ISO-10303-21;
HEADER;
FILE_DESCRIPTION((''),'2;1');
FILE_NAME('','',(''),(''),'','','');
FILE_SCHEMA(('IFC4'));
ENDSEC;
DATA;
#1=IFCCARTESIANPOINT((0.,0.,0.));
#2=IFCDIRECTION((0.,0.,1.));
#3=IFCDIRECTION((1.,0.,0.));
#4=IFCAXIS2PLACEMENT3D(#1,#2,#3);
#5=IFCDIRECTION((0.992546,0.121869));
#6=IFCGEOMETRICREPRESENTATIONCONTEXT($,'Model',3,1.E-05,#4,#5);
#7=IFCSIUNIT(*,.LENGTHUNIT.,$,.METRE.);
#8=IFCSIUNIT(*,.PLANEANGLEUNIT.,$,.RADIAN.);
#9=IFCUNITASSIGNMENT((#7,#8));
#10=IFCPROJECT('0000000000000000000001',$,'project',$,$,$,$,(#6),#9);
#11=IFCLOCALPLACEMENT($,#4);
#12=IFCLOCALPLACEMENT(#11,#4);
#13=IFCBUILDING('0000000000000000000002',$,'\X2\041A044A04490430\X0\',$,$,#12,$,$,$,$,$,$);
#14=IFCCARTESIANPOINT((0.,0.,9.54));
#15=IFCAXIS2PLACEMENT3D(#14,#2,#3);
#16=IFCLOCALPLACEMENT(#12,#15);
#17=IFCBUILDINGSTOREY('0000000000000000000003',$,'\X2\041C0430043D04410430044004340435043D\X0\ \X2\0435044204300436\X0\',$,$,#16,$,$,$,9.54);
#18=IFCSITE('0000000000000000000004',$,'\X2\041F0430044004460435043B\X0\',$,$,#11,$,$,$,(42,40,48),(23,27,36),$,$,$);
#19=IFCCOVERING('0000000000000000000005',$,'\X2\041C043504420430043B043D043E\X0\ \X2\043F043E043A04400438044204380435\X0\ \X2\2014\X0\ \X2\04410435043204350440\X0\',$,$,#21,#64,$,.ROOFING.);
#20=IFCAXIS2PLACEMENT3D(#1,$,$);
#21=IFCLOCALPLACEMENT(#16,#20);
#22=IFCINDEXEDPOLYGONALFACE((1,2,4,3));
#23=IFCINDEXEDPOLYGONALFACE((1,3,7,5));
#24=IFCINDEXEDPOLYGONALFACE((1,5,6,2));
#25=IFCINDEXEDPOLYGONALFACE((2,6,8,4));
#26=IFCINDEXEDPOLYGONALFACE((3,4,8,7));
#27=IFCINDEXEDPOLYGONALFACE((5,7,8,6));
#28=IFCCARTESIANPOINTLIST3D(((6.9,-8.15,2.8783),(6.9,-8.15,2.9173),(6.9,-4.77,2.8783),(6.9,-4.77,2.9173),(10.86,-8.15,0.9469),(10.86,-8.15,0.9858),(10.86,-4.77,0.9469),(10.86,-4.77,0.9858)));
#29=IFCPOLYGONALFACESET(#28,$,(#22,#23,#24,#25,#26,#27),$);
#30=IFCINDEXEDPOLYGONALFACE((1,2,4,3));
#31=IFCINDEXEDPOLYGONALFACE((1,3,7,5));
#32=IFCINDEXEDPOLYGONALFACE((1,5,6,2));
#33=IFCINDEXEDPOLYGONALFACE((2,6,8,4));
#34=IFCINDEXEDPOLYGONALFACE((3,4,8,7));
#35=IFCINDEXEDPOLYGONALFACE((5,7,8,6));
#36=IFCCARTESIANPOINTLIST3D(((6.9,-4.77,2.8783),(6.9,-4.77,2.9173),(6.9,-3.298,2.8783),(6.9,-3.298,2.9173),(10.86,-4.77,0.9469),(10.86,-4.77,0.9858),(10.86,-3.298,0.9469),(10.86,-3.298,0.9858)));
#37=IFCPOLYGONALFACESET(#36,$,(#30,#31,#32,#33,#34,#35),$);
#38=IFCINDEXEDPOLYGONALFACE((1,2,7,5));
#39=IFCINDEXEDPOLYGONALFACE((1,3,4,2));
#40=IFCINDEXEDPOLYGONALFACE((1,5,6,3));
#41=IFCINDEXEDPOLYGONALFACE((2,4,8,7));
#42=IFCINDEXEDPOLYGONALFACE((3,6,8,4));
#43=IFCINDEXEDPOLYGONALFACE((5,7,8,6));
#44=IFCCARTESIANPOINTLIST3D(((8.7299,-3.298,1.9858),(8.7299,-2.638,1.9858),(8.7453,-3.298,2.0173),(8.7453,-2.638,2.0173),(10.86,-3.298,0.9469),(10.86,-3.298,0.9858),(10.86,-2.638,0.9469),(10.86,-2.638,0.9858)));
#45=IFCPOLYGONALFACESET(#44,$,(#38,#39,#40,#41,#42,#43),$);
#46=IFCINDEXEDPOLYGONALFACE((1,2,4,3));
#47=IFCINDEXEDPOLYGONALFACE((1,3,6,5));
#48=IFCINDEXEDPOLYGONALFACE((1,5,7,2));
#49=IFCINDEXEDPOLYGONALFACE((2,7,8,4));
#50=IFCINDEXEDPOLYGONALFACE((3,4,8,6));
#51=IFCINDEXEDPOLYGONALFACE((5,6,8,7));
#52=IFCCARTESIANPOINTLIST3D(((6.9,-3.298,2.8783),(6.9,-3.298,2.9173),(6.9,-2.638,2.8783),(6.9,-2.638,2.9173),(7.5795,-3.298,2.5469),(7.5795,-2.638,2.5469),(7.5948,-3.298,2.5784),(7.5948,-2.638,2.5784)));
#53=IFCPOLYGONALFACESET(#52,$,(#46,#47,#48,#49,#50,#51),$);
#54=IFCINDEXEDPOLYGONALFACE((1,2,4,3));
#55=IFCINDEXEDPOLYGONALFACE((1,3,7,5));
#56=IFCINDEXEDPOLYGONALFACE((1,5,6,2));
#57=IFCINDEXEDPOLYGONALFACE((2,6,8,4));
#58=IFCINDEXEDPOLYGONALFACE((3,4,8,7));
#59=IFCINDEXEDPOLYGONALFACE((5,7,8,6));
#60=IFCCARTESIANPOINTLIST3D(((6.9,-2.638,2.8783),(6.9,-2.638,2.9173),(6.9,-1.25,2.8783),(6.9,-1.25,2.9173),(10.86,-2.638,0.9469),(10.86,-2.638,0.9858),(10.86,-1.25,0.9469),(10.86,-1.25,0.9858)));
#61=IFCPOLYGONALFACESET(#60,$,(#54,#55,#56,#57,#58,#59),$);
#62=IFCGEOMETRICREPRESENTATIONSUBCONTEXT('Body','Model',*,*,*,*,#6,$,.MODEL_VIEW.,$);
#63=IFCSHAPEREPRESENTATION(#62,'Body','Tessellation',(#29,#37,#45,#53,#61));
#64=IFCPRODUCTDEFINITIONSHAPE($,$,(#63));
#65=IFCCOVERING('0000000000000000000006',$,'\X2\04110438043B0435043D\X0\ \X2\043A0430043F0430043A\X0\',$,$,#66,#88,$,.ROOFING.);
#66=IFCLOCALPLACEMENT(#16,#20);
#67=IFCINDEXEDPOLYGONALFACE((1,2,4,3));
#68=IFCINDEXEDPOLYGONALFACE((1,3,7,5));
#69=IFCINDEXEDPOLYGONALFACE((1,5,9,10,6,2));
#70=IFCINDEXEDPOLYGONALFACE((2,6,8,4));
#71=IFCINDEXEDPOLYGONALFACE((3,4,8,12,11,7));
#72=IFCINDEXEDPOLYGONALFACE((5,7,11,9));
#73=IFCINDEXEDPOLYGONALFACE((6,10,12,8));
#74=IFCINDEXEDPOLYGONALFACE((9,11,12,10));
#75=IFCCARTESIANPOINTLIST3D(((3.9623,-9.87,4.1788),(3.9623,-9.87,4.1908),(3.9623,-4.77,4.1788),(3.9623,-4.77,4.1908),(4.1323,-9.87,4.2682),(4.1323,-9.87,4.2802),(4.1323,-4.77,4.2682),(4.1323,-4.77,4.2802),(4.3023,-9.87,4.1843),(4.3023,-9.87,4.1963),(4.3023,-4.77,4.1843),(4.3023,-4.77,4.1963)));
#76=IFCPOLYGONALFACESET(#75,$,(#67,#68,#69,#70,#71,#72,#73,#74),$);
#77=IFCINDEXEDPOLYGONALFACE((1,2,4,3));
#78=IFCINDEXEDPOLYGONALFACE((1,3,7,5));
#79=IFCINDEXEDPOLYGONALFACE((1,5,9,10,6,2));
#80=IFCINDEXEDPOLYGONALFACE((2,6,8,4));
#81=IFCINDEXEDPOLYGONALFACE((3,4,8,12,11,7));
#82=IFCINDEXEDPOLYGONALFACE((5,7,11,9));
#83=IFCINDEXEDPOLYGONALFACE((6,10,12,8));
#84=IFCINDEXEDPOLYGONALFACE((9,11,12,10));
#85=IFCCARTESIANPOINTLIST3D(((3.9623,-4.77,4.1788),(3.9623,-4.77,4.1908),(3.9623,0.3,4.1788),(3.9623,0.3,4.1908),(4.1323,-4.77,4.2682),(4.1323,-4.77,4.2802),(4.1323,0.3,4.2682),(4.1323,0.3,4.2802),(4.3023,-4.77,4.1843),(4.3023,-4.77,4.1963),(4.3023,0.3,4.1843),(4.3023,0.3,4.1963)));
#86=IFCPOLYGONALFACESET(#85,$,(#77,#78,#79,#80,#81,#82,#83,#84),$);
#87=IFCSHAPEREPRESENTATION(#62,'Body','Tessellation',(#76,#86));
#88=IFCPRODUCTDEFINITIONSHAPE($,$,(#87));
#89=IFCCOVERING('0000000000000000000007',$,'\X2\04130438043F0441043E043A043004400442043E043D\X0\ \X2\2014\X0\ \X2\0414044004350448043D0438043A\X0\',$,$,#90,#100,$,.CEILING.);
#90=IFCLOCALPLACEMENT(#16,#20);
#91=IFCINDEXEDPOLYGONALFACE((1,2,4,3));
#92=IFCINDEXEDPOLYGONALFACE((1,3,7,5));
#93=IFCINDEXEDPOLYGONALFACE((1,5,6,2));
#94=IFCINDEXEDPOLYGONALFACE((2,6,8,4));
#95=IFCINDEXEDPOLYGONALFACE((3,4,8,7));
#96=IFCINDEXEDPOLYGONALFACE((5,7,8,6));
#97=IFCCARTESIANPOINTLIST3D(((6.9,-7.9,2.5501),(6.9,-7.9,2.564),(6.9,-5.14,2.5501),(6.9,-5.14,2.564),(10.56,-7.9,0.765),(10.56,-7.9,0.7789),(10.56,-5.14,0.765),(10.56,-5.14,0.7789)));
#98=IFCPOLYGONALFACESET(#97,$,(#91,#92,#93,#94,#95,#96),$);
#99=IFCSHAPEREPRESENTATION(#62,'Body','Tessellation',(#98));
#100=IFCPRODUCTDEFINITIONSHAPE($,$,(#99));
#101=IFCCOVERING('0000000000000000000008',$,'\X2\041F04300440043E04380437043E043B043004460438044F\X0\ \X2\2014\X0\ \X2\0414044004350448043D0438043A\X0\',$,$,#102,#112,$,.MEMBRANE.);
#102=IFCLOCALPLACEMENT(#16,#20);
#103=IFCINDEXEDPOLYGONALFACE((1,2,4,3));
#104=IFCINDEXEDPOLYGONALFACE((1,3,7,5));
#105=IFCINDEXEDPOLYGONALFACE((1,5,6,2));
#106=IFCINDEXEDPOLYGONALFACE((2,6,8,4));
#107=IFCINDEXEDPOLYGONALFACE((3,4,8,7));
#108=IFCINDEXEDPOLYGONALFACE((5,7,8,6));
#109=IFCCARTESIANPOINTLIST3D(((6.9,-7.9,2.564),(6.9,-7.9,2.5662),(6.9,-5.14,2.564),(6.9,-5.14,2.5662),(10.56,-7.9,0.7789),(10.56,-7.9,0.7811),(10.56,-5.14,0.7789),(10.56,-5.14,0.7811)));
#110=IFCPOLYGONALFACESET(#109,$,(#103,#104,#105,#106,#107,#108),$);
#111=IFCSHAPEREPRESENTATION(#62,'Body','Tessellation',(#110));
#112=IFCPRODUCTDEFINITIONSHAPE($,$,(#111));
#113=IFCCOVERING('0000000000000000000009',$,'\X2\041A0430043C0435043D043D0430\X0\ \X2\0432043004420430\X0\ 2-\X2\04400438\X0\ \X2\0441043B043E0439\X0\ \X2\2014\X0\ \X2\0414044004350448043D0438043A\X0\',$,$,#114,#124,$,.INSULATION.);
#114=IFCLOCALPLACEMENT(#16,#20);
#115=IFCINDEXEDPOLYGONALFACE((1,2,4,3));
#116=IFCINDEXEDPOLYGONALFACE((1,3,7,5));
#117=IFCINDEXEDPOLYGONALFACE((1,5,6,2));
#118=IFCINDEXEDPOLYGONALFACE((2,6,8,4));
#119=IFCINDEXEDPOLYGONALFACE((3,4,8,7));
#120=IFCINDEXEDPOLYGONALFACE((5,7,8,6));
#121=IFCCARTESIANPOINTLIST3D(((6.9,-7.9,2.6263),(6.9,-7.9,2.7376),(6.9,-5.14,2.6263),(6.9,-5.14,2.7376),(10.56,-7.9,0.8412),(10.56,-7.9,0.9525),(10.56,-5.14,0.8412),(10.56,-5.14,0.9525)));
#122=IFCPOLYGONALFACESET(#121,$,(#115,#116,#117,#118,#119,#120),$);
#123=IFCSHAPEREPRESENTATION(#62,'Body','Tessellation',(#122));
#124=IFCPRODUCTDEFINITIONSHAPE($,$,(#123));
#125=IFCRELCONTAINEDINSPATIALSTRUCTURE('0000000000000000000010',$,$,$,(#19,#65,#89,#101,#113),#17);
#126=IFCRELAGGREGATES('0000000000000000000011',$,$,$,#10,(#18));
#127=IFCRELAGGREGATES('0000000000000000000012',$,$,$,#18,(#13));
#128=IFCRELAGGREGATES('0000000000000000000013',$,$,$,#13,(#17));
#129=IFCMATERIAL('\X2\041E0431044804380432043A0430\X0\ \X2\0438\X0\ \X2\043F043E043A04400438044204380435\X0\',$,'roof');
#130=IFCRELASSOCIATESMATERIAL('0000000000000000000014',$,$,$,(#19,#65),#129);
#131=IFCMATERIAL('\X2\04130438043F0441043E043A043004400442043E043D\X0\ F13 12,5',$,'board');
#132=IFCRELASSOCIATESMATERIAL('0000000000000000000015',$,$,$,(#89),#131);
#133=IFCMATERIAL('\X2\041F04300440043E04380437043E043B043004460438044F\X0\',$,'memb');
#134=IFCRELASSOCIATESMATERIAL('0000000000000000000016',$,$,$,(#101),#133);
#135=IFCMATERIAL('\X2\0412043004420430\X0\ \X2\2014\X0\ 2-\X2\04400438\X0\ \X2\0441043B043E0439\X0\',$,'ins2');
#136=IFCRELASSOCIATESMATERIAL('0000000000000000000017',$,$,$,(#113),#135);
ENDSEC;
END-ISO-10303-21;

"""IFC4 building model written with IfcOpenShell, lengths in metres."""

from ifc_helpers import new_model, si_unit, direction, frame, origin_with_axes, place, context, subcontext, project, spatial, polyline, outline, extrude, material, element, save


model = new_model("IFC4")

# Units and contexts
model_context = context("Model", 3, precision=1e-05, world=origin_with_axes(), true_north=direction((0.992546, 0.121869)))
body_context = subcontext(model_context, "Body", "Model", "MODEL_VIEW")
ifc_project = project(units=[si_unit("LENGTHUNIT", "METRE"), si_unit("PLANEANGLEUNIT", "RADIAN")], contexts=[model_context])

# Site, building, storey
site_placement = place(None, origin_with_axes())
site = spatial("IfcSite", under=ifc_project, at=site_placement, Name="Парцел", RefLatitude=(42, 40, 48), RefLongitude=(23, 27, 36))
building_placement = place(site_placement, origin_with_axes())
building = spatial("IfcBuilding", under=site, at=building_placement, Name="Къща")
storey_placement = place(building_placement, frame((0.0, 0.0, 9.54), z_axis=(0.0, 0.0, 1.0), x_axis=(1.0, 0.0, 0.0)))
storey = spatial("IfcBuildingStorey", under=building, at=storey_placement, Name="Мансарден етаж", Elevation=9.54)

# Coverings
ifc_material_1 = material(Name="Обшивка и покритие", Category="roof")
covering_1_placement = place(storey_placement, origin_with_axes())
element("IfcCovering", 1, at=covering_1_placement, inside=storey, material=ifc_material_1, Name="Метално покритие — север", PredefinedType="ROOFING", context=body_context, shape_type="SweptSolid", body=[
    extrude(outline(polyline([(10.86, -0.9469), (6.9, -2.8783), (6.9, -2.9173), (10.86, -0.9858), (10.86, -0.9469)])), frame((0.0, -8.15, 0.0), z_axis=(0.0, 1.0, 0.0), x_axis=(1.0, 0.0, 0.0)), (0.0, 0.0, 1.0), 3.38),
    extrude(outline(polyline([(10.86, -0.9469), (6.9, -2.8783), (6.9, -2.9173), (10.86, -0.9858), (10.86, -0.9469)])), frame((0.0, -4.77, 0.0), z_axis=(0.0, 1.0, 0.0), x_axis=(1.0, 0.0, 0.0)), (0.0, 0.0, 1.0), 1.472),
    extrude(outline(polyline([(10.86, -0.9469), (8.7299, -1.9858), (8.7453, -2.0173), (10.86, -0.9858), (10.86, -0.9469)])), frame((0.0, -3.298, 0.0), z_axis=(0.0, 1.0, 0.0), x_axis=(1.0, 0.0, 0.0)), (0.0, 0.0, 1.0), 0.66),
    extrude(outline(polyline([(7.5795, -2.5469), (6.9, -2.8783), (6.9, -2.9173), (7.5948, -2.5784), (7.5795, -2.5469)])), frame((0.0, -3.298, 0.0), z_axis=(0.0, 1.0, 0.0), x_axis=(1.0, 0.0, 0.0)), (0.0, 0.0, 1.0), 0.66),
    extrude(outline(polyline([(10.86, -0.9469), (6.9, -2.8783), (6.9, -2.9173), (10.86, -0.9858), (10.86, -0.9469)])), frame((0.0, -2.638, 0.0), z_axis=(0.0, 1.0, 0.0), x_axis=(1.0, 0.0, 0.0)), (0.0, 0.0, 1.0), 1.388),
])
covering_2_placement = place(storey_placement, origin_with_axes())
element("IfcCovering", 2, at=covering_2_placement, inside=storey, material=ifc_material_1, Name="Билен капак", PredefinedType="ROOFING", context=body_context, shape_type="SweptSolid", body=[
    extrude(outline(polyline([(3.9623, -4.1788), (4.1323, -4.2682), (4.3023, -4.1843), (4.3023, -4.1963), (4.1323, -4.2802), (3.9623, -4.1908), (3.9623, -4.1788)])), frame((0.0, -9.87, 0.0), z_axis=(0.0, 1.0, 0.0), x_axis=(1.0, 0.0, 0.0)), (0.0, 0.0, 1.0), 5.1),
    extrude(outline(polyline([(3.9623, -4.1788), (4.1323, -4.2682), (4.3023, -4.1843), (4.3023, -4.1963), (4.1323, -4.2802), (3.9623, -4.1908), (3.9623, -4.1788)])), frame((0.0, -4.77, 0.0), z_axis=(0.0, 1.0, 0.0), x_axis=(1.0, 0.0, 0.0)), (0.0, 0.0, 1.0), 5.07),
])
ifc_material_2 = material(Name="Гипсокартон F13 12,5", Category="board")
covering_3_placement = place(storey_placement, origin_with_axes())
element("IfcCovering", 3, at=covering_3_placement, inside=storey, material=ifc_material_2, Name="Гипсокартон — Дрешник", PredefinedType="CEILING", context=body_context, shape_type="SweptSolid", body=[
    extrude(outline(polyline([(10.56, -0.765), (6.9, -2.5501), (6.9, -2.564), (10.56, -0.7789), (10.56, -0.765)])), frame((0.0, -7.9, 0.0), z_axis=(0.0, 1.0, 0.0), x_axis=(1.0, 0.0, 0.0)), (0.0, 0.0, 1.0), 2.76),
])
ifc_material_3 = material(Name="Пароизолация", Category="memb")
covering_4_placement = place(storey_placement, origin_with_axes())
element("IfcCovering", 4, at=covering_4_placement, inside=storey, material=ifc_material_3, Name="Пароизолация — Дрешник", PredefinedType="MEMBRANE", context=body_context, shape_type="SweptSolid", body=[
    extrude(outline(polyline([(10.56, -0.7789), (6.9, -2.564), (6.9, -2.5662), (10.56, -0.7811), (10.56, -0.7789)])), frame((0.0, -7.9, 0.0), z_axis=(0.0, 1.0, 0.0), x_axis=(1.0, 0.0, 0.0)), (0.0, 0.0, 1.0), 2.76),
])
ifc_material_4 = material(Name="Вата — 2-ри слой", Category="ins2")
covering_5_placement = place(storey_placement, origin_with_axes())
element("IfcCovering", 5, at=covering_5_placement, inside=storey, material=ifc_material_4, Name="Каменна вата 2-ри слой — Дрешник", PredefinedType="INSULATION", context=body_context, shape_type="SweptSolid", body=[
    extrude(outline(polyline([(10.56, -0.8412), (6.9, -2.6263), (6.9, -2.7376), (10.56, -0.9525), (10.56, -0.8412)])), frame((0.0, -7.9, 0.0), z_axis=(0.0, 1.0, 0.0), x_axis=(1.0, 0.0, 0.0)), (0.0, 0.0, 1.0), 2.76),
])

save(model, "model.ifc")
